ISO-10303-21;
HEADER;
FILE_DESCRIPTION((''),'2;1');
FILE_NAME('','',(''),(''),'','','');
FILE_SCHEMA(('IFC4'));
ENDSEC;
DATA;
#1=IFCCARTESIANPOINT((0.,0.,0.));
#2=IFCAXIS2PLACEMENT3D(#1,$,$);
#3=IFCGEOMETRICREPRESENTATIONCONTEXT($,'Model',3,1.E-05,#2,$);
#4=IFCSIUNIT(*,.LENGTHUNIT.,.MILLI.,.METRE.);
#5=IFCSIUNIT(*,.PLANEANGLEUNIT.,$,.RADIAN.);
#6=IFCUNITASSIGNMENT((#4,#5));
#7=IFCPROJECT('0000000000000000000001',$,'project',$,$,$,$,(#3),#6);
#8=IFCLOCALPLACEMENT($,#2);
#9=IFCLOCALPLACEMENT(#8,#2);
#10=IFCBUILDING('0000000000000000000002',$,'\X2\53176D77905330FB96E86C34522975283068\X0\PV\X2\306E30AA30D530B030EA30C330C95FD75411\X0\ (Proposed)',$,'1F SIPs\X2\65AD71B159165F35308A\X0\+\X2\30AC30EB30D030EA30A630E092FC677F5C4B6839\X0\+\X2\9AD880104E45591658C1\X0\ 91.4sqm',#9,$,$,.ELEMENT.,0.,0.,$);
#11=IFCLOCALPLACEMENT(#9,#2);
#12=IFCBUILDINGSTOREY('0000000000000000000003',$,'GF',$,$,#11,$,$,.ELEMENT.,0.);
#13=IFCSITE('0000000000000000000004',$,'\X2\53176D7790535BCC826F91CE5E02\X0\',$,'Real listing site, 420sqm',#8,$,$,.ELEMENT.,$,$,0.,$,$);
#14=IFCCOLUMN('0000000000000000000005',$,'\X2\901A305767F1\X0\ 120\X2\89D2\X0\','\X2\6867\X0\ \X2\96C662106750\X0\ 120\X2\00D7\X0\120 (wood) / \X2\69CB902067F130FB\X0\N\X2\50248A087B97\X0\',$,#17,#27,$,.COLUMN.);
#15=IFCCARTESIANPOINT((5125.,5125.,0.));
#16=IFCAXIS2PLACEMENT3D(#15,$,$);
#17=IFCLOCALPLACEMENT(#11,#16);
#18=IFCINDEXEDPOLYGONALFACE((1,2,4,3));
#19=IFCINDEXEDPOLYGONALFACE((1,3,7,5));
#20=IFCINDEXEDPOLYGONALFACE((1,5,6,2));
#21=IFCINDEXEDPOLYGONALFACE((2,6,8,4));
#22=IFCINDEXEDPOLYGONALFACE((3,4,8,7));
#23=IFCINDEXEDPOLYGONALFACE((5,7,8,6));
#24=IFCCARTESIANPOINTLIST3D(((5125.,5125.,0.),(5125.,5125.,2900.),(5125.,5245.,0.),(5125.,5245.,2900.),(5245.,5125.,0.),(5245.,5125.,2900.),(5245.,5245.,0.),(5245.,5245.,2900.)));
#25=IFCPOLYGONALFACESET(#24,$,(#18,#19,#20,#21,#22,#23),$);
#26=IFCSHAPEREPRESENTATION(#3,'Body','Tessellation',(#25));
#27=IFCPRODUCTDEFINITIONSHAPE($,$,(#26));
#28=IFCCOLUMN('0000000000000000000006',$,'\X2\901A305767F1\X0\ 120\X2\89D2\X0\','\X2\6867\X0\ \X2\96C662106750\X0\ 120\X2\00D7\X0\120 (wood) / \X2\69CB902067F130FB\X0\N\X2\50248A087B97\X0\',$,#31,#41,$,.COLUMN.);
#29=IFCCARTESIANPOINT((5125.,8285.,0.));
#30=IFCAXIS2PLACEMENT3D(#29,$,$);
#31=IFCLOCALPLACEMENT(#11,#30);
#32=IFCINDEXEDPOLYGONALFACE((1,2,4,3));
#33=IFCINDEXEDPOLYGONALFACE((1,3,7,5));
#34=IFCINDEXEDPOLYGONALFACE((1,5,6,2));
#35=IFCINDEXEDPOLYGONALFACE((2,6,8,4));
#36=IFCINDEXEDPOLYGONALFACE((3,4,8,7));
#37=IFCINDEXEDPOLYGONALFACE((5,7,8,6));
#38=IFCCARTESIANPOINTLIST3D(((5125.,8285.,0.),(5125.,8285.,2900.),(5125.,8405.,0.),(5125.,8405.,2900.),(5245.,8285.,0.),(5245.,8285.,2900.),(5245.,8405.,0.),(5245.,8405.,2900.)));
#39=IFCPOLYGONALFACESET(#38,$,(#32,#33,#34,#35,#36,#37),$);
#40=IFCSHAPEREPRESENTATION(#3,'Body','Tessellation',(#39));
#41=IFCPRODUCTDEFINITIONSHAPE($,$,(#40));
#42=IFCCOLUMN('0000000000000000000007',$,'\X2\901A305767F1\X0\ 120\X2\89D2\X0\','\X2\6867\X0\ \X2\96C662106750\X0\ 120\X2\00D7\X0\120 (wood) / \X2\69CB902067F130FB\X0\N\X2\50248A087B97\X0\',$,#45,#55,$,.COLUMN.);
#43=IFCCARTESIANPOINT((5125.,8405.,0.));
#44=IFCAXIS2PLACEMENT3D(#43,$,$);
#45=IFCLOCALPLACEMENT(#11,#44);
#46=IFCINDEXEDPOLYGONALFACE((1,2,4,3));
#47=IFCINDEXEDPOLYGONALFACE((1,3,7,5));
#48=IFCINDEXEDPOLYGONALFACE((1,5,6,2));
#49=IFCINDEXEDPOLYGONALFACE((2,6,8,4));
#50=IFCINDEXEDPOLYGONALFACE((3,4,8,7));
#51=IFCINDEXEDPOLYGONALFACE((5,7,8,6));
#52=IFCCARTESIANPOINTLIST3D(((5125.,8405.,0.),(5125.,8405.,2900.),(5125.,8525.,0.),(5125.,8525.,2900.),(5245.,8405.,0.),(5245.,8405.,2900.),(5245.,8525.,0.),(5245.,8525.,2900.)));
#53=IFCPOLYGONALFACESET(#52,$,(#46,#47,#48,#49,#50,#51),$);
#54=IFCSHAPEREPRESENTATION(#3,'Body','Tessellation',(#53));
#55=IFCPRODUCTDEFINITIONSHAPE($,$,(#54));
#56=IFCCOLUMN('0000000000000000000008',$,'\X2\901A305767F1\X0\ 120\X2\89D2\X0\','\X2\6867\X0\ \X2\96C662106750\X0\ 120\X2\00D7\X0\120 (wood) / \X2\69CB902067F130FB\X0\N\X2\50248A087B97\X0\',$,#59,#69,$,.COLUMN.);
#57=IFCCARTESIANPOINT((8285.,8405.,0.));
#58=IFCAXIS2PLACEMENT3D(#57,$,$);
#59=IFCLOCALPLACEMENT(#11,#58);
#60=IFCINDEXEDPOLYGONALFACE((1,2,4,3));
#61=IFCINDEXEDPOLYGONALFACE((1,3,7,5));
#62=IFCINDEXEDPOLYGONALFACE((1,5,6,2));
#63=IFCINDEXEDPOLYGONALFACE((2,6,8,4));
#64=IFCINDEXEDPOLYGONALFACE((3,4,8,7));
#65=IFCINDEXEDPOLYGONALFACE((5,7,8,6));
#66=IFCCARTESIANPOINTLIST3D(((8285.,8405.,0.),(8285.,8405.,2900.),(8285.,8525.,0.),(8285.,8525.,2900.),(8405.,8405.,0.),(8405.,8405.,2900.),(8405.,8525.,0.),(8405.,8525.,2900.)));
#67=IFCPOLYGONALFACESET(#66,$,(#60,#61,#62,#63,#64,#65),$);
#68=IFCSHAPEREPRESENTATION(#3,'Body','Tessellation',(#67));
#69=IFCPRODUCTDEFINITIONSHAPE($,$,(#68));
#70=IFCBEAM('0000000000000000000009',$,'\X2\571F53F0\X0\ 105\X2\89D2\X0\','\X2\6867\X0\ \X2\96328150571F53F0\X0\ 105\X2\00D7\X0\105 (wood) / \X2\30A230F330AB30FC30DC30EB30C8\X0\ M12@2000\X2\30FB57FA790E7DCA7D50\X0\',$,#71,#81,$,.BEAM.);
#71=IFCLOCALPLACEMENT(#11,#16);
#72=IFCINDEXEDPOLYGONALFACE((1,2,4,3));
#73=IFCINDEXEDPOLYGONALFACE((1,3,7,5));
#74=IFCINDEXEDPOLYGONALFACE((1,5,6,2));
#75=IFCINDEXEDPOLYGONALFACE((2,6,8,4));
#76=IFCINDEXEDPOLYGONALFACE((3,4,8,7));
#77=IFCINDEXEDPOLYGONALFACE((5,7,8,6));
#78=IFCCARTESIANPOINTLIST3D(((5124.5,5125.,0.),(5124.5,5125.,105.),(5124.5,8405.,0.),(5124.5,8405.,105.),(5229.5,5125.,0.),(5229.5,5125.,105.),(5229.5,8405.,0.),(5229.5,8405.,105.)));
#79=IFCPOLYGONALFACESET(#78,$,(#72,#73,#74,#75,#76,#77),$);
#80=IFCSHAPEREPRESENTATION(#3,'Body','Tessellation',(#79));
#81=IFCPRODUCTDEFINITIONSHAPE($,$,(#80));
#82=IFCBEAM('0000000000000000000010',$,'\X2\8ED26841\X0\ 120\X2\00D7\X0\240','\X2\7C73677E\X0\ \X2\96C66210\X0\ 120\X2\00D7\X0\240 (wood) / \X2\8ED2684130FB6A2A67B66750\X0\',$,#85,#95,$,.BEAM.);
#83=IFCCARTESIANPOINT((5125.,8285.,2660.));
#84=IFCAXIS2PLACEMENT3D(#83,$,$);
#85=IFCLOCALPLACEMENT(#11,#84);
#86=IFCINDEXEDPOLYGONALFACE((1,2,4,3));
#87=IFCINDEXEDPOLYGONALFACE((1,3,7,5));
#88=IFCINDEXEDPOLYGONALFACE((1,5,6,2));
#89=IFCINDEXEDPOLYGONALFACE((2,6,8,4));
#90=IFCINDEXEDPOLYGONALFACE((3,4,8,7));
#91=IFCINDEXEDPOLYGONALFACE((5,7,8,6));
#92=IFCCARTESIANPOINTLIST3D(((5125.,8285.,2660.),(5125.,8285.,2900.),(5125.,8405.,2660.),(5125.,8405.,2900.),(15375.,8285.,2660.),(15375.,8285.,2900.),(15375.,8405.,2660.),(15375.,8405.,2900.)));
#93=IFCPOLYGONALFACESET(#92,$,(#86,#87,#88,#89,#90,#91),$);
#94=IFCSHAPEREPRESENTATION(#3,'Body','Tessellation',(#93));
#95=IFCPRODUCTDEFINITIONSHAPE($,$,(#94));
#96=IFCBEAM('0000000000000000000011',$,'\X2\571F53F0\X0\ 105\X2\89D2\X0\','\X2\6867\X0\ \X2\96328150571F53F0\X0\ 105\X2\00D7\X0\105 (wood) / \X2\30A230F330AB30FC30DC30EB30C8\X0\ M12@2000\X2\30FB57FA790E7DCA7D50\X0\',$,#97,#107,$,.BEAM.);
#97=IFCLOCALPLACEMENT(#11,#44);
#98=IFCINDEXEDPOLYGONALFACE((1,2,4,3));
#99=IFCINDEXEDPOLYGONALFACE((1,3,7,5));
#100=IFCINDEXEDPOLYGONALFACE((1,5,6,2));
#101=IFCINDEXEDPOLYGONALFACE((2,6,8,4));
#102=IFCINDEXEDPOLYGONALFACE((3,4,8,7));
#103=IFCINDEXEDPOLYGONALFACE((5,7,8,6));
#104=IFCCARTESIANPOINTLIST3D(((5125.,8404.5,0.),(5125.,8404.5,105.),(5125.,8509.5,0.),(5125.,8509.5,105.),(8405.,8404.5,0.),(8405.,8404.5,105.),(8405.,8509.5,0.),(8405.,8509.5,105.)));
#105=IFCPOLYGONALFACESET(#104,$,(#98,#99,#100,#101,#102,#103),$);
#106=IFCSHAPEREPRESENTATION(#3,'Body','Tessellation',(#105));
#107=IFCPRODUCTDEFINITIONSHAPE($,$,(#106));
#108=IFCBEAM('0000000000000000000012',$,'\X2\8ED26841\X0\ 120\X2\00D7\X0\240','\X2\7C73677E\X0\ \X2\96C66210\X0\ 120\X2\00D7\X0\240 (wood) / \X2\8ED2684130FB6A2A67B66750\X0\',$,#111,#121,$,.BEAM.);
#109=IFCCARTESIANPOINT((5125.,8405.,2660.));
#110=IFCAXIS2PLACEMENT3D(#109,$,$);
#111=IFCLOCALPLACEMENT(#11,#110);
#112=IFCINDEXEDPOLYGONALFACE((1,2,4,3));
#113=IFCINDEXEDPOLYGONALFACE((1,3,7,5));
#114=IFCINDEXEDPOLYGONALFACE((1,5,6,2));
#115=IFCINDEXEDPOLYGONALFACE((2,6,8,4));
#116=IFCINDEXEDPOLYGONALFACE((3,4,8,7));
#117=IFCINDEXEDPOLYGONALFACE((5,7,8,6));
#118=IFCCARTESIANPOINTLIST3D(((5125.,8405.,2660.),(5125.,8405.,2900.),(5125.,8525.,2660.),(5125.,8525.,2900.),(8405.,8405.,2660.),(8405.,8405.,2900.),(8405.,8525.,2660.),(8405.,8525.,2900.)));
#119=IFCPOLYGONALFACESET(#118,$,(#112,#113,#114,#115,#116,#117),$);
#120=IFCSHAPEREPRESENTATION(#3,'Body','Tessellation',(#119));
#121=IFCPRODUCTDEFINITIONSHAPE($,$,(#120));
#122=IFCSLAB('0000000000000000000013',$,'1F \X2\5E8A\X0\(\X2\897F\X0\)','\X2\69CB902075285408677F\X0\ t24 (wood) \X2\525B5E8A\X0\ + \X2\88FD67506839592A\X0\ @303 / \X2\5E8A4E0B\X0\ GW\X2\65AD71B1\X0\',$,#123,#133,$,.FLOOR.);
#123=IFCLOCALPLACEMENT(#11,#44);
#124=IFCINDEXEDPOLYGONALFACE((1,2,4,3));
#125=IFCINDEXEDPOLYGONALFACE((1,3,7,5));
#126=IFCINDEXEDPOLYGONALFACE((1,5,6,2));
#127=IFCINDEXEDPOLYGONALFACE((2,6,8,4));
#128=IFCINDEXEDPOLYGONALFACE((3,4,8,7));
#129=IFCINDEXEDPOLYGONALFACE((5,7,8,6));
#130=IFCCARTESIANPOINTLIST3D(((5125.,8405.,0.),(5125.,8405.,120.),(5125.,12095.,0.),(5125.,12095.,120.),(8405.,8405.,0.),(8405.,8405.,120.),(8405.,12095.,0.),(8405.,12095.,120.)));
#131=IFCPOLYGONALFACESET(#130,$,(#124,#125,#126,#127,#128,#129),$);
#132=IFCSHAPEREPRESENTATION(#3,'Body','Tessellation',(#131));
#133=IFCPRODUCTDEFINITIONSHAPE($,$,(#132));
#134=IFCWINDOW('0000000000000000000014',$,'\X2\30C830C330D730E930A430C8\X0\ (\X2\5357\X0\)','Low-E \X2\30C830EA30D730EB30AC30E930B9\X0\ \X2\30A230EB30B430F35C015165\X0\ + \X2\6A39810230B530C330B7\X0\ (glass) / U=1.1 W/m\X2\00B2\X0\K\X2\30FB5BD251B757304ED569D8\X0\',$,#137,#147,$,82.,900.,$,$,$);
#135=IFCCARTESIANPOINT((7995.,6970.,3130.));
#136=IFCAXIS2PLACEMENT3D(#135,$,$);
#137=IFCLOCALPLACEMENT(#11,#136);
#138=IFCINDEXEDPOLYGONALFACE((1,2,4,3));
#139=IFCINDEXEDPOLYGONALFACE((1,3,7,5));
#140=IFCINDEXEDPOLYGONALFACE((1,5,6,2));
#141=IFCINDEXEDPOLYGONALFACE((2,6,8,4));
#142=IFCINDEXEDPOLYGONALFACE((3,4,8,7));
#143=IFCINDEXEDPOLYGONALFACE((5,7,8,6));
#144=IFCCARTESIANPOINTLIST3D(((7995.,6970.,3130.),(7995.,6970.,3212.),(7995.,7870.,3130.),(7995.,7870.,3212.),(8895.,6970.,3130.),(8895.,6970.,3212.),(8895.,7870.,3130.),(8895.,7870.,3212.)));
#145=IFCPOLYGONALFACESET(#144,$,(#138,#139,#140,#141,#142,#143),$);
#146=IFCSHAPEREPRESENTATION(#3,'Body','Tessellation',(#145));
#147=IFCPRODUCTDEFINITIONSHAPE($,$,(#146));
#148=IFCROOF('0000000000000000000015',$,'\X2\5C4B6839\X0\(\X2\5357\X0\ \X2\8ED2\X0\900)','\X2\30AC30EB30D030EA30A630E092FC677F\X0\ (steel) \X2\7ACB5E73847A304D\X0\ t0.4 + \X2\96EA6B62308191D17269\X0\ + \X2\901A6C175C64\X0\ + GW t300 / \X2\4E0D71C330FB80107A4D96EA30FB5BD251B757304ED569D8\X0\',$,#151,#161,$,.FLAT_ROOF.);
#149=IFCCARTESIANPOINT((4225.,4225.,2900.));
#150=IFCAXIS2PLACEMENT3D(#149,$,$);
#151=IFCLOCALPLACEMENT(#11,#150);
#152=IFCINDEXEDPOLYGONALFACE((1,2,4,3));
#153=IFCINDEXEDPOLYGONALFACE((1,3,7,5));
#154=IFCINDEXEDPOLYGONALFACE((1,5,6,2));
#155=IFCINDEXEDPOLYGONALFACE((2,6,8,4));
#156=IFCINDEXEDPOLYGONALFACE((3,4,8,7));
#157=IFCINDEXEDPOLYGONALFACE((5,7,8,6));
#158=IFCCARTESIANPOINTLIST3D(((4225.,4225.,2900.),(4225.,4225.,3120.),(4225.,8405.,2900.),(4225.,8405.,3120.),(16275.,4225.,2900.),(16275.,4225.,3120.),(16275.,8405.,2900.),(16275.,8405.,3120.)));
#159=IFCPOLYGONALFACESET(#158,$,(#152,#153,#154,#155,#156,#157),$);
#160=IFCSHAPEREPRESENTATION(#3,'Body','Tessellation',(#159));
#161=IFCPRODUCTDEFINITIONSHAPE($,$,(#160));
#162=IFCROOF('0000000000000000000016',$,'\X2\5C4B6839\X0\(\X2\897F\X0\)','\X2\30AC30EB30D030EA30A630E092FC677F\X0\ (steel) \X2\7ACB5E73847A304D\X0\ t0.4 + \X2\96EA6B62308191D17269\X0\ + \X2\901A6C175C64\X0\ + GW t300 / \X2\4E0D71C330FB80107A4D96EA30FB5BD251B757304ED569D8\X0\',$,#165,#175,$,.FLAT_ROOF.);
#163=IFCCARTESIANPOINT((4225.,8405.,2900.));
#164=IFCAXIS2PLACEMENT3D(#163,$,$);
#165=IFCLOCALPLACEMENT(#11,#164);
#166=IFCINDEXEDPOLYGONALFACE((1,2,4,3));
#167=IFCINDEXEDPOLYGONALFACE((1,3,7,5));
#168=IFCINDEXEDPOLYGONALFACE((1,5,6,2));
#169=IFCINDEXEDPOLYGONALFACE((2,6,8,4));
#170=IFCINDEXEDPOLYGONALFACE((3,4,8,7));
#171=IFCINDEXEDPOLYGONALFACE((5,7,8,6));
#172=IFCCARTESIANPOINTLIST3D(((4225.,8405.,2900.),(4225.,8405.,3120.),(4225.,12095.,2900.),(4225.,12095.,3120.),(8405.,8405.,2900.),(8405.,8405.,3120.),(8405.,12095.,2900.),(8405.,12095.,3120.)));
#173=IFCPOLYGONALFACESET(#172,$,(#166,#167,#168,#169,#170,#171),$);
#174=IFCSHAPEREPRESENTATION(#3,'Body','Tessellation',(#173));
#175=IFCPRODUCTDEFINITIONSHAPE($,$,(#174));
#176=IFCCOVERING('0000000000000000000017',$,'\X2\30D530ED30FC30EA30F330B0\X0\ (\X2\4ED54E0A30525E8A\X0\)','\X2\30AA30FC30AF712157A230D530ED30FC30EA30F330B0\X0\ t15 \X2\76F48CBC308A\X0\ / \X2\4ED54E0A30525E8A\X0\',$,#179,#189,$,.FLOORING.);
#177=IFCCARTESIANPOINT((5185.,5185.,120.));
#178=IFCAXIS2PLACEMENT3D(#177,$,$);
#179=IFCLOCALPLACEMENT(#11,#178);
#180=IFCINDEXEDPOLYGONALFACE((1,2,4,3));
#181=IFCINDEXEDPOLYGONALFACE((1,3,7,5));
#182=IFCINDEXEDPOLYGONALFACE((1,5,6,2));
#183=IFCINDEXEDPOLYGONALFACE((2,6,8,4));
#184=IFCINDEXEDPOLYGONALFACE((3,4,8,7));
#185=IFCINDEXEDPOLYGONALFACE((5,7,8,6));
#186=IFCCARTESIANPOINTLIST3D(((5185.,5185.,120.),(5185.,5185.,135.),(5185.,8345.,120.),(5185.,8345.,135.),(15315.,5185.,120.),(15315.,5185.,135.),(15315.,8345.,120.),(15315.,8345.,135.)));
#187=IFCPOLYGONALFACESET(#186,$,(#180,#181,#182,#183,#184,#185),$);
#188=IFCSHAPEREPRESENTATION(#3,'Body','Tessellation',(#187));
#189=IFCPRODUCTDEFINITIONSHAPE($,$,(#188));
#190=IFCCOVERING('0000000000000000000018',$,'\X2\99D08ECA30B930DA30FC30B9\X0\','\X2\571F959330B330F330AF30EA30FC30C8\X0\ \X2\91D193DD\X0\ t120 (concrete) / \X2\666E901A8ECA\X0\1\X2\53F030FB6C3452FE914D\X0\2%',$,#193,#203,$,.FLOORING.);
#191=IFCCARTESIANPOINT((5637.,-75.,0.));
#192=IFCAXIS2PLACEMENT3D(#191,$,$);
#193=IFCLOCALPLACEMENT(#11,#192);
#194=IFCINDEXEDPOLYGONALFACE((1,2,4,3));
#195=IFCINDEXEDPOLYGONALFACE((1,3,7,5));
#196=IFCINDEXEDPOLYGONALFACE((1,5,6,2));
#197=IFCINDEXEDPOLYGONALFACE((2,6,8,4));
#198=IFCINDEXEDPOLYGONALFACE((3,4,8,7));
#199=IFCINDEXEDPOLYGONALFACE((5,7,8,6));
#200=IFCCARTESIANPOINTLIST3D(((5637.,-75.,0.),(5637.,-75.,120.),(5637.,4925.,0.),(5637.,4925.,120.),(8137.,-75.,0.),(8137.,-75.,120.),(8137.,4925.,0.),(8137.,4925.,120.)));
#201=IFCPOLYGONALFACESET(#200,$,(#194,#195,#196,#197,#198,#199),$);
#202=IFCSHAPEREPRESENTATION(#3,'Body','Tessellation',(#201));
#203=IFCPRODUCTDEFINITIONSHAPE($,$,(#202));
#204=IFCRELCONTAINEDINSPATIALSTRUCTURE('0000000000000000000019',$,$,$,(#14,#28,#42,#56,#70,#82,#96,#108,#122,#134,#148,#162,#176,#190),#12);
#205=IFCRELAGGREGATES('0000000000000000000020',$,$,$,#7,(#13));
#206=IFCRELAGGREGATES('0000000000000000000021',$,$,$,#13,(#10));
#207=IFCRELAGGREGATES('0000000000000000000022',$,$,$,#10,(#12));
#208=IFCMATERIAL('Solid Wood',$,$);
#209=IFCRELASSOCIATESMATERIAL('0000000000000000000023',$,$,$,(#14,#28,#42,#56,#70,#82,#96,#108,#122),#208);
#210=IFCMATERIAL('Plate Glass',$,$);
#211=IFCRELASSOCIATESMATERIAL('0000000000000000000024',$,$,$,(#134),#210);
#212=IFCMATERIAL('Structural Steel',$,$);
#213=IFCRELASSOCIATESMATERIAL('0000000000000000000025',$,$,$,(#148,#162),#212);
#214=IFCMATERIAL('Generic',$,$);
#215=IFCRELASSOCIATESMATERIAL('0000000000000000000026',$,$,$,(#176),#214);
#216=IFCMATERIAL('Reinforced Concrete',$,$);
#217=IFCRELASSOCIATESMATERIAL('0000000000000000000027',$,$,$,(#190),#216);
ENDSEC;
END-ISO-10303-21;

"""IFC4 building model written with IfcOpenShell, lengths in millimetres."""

from ifc_helpers import new_model, si_unit, frame, frame_2d, origin, place, context, project, spatial, rectangle, extrude, material, element, save


model = new_model("IFC4")

# Units and contexts
model_context = context("Model", 3, precision=1e-05, world=origin())
ifc_project = project(units=[si_unit("LENGTHUNIT", "METRE", prefix="MILLI"), si_unit("PLANEANGLEUNIT", "RADIAN")], contexts=[model_context])

# Site, building, storey
site_placement = place(None, origin())
site = spatial("IfcSite", under=ifc_project, at=site_placement, Name="北海道富良野市", ObjectType="Real listing site, 420sqm", CompositionType="ELEMENT", RefElevation=0.0)
building_placement = place(site_placement, origin())
building = spatial("IfcBuilding", under=site, at=building_placement, Name="北海道・雨水利用とPVのオフグリッド志向 (Proposed)", ObjectType="1F SIPs断熱外張り+ガルバリウム鋼板屋根+高耐久外壁 91.4sqm", CompositionType="ELEMENT", ElevationOfRefHeight=0.0, ElevationOfTerrain=0.0)
storey_placement = place(building_placement, origin())
storey = spatial("IfcBuildingStorey", under=building, at=storey_placement, Name="GF", CompositionType="ELEMENT", Elevation=0.0)

# Columns
ifc_material_1 = material(Name="Solid Wood")
column_1_placement = place(storey_placement, frame((5125.0, 5125.0, 0.0)))
element("IfcColumn", 1, at=column_1_placement, inside=storey, material=ifc_material_1, Name="通し柱 120角", Description="桧 集成材 120×120 (wood) / 構造柱・N値計算", PredefinedType="COLUMN", context=model_context, shape_type="SweptSolid", body=[
    extrude(rectangle(XDim=120.0, YDim=120.0, at=frame_2d((60.0, 60.0))), frame((5125.0, 5125.0, 0.0)), (0.0, 0.0, 1.0), 2900.0),
])
column_2_placement = place(storey_placement, frame((5125.0, 8285.0, 0.0)))
element("IfcColumn", 2, at=column_2_placement, inside=storey, material=ifc_material_1, Name="通し柱 120角", Description="桧 集成材 120×120 (wood) / 構造柱・N値計算", PredefinedType="COLUMN", context=model_context, shape_type="SweptSolid", body=[
    extrude(rectangle(XDim=120.0, YDim=120.0, at=frame_2d((60.0, 60.0))), frame((5125.0, 8285.0, 0.0)), (0.0, 0.0, 1.0), 2900.0),
])
column_3_placement = place(storey_placement, frame((5125.0, 8405.0, 0.0)))
element("IfcColumn", 3, at=column_3_placement, inside=storey, material=ifc_material_1, Name="通し柱 120角", Description="桧 集成材 120×120 (wood) / 構造柱・N値計算", PredefinedType="COLUMN", context=model_context, shape_type="SweptSolid", body=[
    extrude(rectangle(XDim=120.0, YDim=120.0, at=frame_2d((60.0, 60.0))), frame((5125.0, 8405.0, 0.0)), (0.0, 0.0, 1.0), 2900.0),
])
column_4_placement = place(storey_placement, frame((8285.0, 8405.0, 0.0)))
element("IfcColumn", 4, at=column_4_placement, inside=storey, material=ifc_material_1, Name="通し柱 120角", Description="桧 集成材 120×120 (wood) / 構造柱・N値計算", PredefinedType="COLUMN", context=model_context, shape_type="SweptSolid", body=[
    extrude(rectangle(XDim=120.0, YDim=120.0, at=frame_2d((60.0, 60.0))), frame((8285.0, 8405.0, 0.0)), (0.0, 0.0, 1.0), 2900.0),
])

# Beams
beam_1_placement = place(storey_placement, frame((5125.0, 5125.0, 0.0)))
element("IfcBeam", 5, at=beam_1_placement, inside=storey, material=ifc_material_1, Name="土台 105角", Description="桧 防腐土台 105×105 (wood) / アンカーボルト M12@2000・基礎緊結", PredefinedType="BEAM", context=model_context, shape_type="SweptSolid", body=[
    extrude(rectangle(XDim=105.0, YDim=3280.0, at=frame_2d((52.0, 1640.0))), frame((5125.0, 5125.0, 0.0)), (0.0, 0.0, 1.0), 105.0),
])
beam_2_placement = place(storey_placement, frame((5125.0, 8285.0, 2660.0)))
element("IfcBeam", 6, at=beam_2_placement, inside=storey, material=ifc_material_1, Name="軒桁 120×240", Description="米松 集成 120×240 (wood) / 軒桁・横架材", PredefinedType="BEAM", context=model_context, shape_type="SweptSolid", body=[
    extrude(rectangle(XDim=10250.0, YDim=120.0, at=frame_2d((5125.0, 60.0))), frame((5125.0, 8285.0, 2660.0)), (0.0, 0.0, 1.0), 240.0),
])
beam_3_placement = place(storey_placement, frame((5125.0, 8405.0, 0.0)))
element("IfcBeam", 7, at=beam_3_placement, inside=storey, material=ifc_material_1, Name="土台 105角", Description="桧 防腐土台 105×105 (wood) / アンカーボルト M12@2000・基礎緊結", PredefinedType="BEAM", context=model_context, shape_type="SweptSolid", body=[
    extrude(rectangle(XDim=3280.0, YDim=105.0, at=frame_2d((1640.0, 52.0))), frame((5125.0, 8405.0, 0.0)), (0.0, 0.0, 1.0), 105.0),
])
beam_4_placement = place(storey_placement, frame((5125.0, 8405.0, 2660.0)))
element("IfcBeam", 8, at=beam_4_placement, inside=storey, material=ifc_material_1, Name="軒桁 120×240", Description="米松 集成 120×240 (wood) / 軒桁・横架材", PredefinedType="BEAM", context=model_context, shape_type="SweptSolid", body=[
    extrude(rectangle(XDim=3280.0, YDim=120.0, at=frame_2d((1640.0, 60.0))), frame((5125.0, 8405.0, 2660.0)), (0.0, 0.0, 1.0), 240.0),
])

# Slab
ifc_material_2 = material(Name="Reinforced Concrete")
slab_1_placement = place(storey_placement, frame((5125.0, 8405.0, 0.0)))
element("IfcSlab", 9, at=slab_1_placement, inside=storey, material=ifc_material_1, Name="1F 床(西)", Description="構造用合板 t24 (wood) 剛床 + 製材根太 @303 / 床下 GW断熱", PredefinedType="FLOOR", context=model_context, shape_type="SweptSolid", body=[
    extrude(rectangle(XDim=3280.0, YDim=3690.0, at=frame_2d((1640.0, 1845.0))), frame((5125.0, 8405.0, 0.0)), (0.0, 0.0, 1.0), 120.0),
])

# Shared definitions
ifc_material_3 = material(Name="Plate Glass")

# Window
window_1_placement = place(storey_placement, frame((7995.0, 6970.0, 3130.0)))
element("IfcWindow", 10, at=window_1_placement, inside=storey, material=ifc_material_3, Name="トップライト (南)", Description="Low-E トリプルガラス アルゴン封入 + 樹脂サッシ (glass) / U=1.1 W/m²K・寒冷地仕様", OverallHeight=82.0, OverallWidth=900.0, context=model_context, shape_type="SweptSolid", body=[
    extrude(rectangle(XDim=900.0, YDim=900.0, at=frame_2d((450.0, 450.0))), frame((7995.0, 6970.0, 3130.0)), (0.0, 0.0, 1.0), 82.0),
])

# Roofs
ifc_material_4 = material(Name="Structural Steel")
roof_1_placement = place(storey_placement, frame((4225.0, 4225.0, 2900.0)))
element("IfcRoof", 11, at=roof_1_placement, inside=storey, material=ifc_material_4, Name="屋根(南 軒900)", Description="ガルバリウム鋼板 (steel) 立平葺き t0.4 + 雪止め金物 + 通気層 + GW t300 / 不燃・耐積雪・寒冷地仕様", PredefinedType="FLAT_ROOF", context=model_context, shape_type="SweptSolid", body=[
    extrude(rectangle(XDim=12050.0, YDim=4180.0, at=frame_2d((6025.0, 2090.0))), frame((4225.0, 4225.0, 2900.0)), (0.0, 0.0, 1.0), 220.0),
])
roof_2_placement = place(storey_placement, frame((4225.0, 8405.0, 2900.0)))
element("IfcRoof", 12, at=roof_2_placement, inside=storey, material=ifc_material_4, Name="屋根(西)", Description="ガルバリウム鋼板 (steel) 立平葺き t0.4 + 雪止め金物 + 通気層 + GW t300 / 不燃・耐積雪・寒冷地仕様", PredefinedType="FLAT_ROOF", context=model_context, shape_type="SweptSolid", body=[
    extrude(rectangle(XDim=4180.0, YDim=3690.0, at=frame_2d((2090.0, 1845.0))), frame((4225.0, 8405.0, 2900.0)), (0.0, 0.0, 1.0), 220.0),
])

# Coverings
ifc_material_5 = material(Name="Generic")
covering_1_placement = place(storey_placement, frame((5185.0, 5185.0, 120.0)))
element("IfcCovering", 13, at=covering_1_placement, inside=storey, material=ifc_material_5, Name="フローリング (仕上げ床)", Description="オーク無垢フローリング t15 直貼り / 仕上げ床", PredefinedType="FLOORING", context=model_context, shape_type="SweptSolid", body=[
    extrude(rectangle(XDim=10130.0, YDim=3160.0, at=frame_2d((5065.0, 1580.0))), frame((5185.0, 5185.0, 120.0)), (0.0, 0.0, 1.0), 15.0),
])
covering_2_placement = place(storey_placement, frame((5637.0, -75.0, 0.0)))
element("IfcCovering", 14, at=covering_2_placement, inside=storey, material=ifc_material_2, Name="駐車スペース", Description="土間コンクリート 金鏝 t120 (concrete) / 普通車1台・水勾配2%", PredefinedType="FLOORING", context=model_context, shape_type="SweptSolid", body=[
    extrude(rectangle(XDim=2500.0, YDim=5000.0, at=frame_2d((1250.0, 2500.0))), frame((5637.0, -75.0, 0.0)), (0.0, 0.0, 1.0), 120.0),
])

save(model, "model.ifc")
